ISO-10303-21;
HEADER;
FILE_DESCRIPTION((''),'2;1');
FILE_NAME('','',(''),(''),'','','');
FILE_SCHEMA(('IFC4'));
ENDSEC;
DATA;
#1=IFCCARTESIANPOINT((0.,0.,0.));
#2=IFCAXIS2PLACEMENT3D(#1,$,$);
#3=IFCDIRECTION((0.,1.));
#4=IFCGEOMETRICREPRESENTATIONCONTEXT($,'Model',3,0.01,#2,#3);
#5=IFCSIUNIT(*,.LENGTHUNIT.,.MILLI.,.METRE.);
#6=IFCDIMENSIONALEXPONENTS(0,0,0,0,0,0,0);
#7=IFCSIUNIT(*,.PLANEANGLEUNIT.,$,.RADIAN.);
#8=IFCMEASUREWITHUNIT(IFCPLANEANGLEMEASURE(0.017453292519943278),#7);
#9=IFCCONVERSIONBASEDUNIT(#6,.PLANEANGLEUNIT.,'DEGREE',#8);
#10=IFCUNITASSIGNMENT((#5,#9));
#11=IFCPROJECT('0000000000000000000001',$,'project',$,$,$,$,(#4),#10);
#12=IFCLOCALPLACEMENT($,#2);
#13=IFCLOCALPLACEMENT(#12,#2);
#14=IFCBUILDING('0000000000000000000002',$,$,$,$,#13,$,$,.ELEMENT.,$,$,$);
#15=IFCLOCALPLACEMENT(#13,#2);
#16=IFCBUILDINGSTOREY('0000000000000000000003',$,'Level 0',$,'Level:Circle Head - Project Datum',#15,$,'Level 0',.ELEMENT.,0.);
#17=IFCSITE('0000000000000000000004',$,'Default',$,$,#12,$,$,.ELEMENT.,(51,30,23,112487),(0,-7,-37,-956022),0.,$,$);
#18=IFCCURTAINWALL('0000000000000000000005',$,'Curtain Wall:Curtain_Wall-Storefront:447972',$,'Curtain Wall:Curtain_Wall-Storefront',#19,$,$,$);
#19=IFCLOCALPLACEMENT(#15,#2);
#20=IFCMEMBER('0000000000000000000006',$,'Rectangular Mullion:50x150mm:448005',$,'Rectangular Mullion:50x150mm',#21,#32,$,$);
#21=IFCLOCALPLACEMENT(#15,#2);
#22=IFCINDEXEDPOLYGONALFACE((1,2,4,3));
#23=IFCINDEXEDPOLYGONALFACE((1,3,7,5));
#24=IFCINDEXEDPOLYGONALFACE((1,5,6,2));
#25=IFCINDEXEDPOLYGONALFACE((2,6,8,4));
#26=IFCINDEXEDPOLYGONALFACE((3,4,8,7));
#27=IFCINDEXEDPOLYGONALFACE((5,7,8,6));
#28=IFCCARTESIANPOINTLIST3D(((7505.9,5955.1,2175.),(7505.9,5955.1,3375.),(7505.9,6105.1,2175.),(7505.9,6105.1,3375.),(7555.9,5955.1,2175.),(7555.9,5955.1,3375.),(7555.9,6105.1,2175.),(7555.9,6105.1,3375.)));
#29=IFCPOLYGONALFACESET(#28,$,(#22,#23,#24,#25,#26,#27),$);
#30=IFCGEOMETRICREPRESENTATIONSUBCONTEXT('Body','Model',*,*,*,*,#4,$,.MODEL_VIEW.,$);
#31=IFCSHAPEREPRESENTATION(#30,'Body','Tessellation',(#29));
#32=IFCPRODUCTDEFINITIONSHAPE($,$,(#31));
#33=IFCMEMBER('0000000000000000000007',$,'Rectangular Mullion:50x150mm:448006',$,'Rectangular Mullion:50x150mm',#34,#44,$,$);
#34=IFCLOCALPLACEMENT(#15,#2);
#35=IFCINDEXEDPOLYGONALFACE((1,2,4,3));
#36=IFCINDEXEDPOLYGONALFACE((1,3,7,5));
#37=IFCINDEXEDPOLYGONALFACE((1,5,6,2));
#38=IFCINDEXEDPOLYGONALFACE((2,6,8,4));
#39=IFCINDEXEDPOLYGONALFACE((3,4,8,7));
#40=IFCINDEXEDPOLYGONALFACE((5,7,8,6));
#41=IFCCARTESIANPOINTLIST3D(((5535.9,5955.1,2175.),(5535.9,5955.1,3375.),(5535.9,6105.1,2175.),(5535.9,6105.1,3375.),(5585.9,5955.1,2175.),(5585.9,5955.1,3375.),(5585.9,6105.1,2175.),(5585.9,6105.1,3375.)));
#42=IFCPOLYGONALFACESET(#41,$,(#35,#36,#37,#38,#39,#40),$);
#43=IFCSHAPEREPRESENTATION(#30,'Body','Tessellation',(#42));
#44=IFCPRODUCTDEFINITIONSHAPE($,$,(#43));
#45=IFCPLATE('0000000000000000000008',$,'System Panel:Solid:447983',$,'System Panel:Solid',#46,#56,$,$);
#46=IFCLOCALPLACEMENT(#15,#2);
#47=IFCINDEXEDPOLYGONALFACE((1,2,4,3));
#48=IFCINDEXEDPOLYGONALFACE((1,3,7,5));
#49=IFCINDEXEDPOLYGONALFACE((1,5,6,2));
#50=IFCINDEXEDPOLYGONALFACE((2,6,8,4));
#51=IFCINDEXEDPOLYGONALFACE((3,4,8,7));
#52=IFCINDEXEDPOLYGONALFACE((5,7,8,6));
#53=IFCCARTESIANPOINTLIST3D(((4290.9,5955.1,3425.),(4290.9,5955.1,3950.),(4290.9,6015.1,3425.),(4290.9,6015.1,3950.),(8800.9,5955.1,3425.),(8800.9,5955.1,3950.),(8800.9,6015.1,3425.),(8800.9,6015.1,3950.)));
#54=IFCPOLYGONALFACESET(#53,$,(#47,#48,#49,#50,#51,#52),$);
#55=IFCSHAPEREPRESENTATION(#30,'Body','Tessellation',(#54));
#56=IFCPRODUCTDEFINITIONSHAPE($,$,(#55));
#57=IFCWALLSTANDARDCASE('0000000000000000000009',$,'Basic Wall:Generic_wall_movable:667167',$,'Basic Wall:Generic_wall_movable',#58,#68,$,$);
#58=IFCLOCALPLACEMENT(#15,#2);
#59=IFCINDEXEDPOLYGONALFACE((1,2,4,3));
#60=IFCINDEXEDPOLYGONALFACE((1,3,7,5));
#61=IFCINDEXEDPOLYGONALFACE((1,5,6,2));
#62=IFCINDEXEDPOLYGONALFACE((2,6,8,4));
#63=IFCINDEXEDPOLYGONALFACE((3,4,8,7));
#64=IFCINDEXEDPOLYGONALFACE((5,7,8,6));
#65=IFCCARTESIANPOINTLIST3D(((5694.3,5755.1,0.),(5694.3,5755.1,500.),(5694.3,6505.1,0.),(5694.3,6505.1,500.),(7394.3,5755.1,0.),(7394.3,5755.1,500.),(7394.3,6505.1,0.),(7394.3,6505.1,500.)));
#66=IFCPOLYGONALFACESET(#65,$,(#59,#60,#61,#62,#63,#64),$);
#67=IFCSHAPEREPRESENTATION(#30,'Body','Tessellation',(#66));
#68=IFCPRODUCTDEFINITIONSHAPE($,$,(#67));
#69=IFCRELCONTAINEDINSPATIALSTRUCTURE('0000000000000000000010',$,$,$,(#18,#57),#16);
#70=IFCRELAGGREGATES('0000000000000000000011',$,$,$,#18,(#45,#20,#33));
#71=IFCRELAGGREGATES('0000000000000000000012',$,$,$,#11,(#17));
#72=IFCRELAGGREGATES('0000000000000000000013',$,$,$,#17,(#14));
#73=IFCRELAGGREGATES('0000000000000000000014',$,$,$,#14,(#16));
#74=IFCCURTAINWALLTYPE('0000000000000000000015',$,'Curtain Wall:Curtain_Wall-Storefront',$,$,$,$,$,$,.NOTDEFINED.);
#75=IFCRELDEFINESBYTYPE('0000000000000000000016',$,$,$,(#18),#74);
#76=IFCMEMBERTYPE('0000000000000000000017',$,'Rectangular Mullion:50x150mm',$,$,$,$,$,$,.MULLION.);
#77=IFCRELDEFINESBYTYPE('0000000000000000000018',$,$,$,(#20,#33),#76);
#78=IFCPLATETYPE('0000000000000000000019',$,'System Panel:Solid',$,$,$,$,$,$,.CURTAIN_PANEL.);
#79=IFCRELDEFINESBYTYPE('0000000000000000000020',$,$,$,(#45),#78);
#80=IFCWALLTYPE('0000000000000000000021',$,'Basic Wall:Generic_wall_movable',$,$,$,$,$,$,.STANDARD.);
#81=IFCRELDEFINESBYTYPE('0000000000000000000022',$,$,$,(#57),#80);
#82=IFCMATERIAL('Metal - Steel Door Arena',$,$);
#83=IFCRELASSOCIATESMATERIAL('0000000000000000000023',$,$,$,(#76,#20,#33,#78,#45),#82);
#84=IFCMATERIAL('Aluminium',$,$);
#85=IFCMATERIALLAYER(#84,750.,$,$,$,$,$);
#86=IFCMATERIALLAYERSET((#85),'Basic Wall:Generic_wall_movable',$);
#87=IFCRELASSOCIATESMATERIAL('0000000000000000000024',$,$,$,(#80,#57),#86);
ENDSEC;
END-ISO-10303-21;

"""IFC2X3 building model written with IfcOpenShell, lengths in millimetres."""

from ifc_helpers import new_model, entity, si_unit, converted_unit, direction, frame, frame_2d, origin, origin_2d_with_axis, place, context, subcontext, project, spatial, rectangle, extrude, source, transform, mapped, material, layer, layer_set, layer_usage, type_object, type_shapes, element, aggregate, save


model = new_model("IFC2X3")

# Units and contexts
model_context = context("Model", 3, precision=0.01, world=origin(), true_north=direction((0.0, 1.0)))
body_context = subcontext(model_context, "Body", "Model", "MODEL_VIEW")
ifc_project = project(units=[si_unit("LENGTHUNIT", "METRE", prefix="MILLI"), converted_unit("PLANEANGLEUNIT", "DEGREE", entity("IfcPlaneAngleMeasure", 0.017453292519943278), si_unit("PLANEANGLEUNIT", "RADIAN"), dimensions=[0, 0, 0, 0, 0, 0, 0])], contexts=[model_context])

# Site, building, storey
site_placement = place(None, origin())
site = spatial("IfcSite", under=ifc_project, at=site_placement, Name="Default", CompositionType="ELEMENT", RefLatitude=(51, 30, 23, 112487), RefLongitude=(0, -7, -37, -956022), RefElevation=0.0)
building_placement = place(site_placement, origin())
building = spatial("IfcBuilding", under=site, at=building_placement, CompositionType="ELEMENT")
storey_placement = place(building_placement, origin())
storey = spatial("IfcBuildingStorey", under=building, at=storey_placement, Name="Level 0", ObjectType="Level:Circle Head - Project Datum", LongName="Level 0", CompositionType="ELEMENT", Elevation=0.0)

# Curtain wall, members, plate
curtain_wall_type = type_object("IfcCurtainWallType", Name="Curtain Wall:Curtain_Wall-Storefront", PredefinedType="NOTDEFINED")
curtain_wall_placement = place(storey_placement, origin())
curtain_wall = element("IfcCurtainWall", 1, at=curtain_wall_placement, inside=storey, type_object=curtain_wall_type, Name="Curtain Wall:Curtain_Wall-Storefront:447972", ObjectType="Curtain Wall:Curtain_Wall-Storefront")
ifc_material_1 = material(Name="Metal - Steel Door Arena")
member_type_1 = type_object("IfcMemberType", Name="Rectangular Mullion:50x150mm", PredefinedType="MULLION", material=ifc_material_1)
shared_shape_1 = source(origin(), body_context, "Body", "SweptSolid", [
    extrude(rectangle(XDim=50.0, YDim=150.0, at=origin_2d_with_axis()), frame((0.0, 0.0, -1200.0), z_axis=(0.0, 0.0, 1.0), x_axis=(-1.0, 0.0, 0.0)), (0.0, 0.0, 1.0), 1200.0),
])
type_shapes(member_type_1, [shared_shape_1])
member_1_placement = place(curtain_wall_placement, frame((7530.9, 6030.1, 2175.0), z_axis=(0.0, 0.0, -1.0), x_axis=(-1.0, 0.0, 0.0)))
member_1 = element("IfcMember", 2, at=member_1_placement, type_object=member_type_1, material=ifc_material_1, Name="Rectangular Mullion:50x150mm:448005", ObjectType="Rectangular Mullion:50x150mm", context=body_context, shape_type="MappedRepresentation", body=[
    mapped(shared_shape_1, transform((0.0, 0.0, 0.0), scale=1.0)),
])
member_2_placement = place(curtain_wall_placement, frame((5560.9, 6030.1, 2175.0), z_axis=(0.0, 0.0, -1.0), x_axis=(-1.0, 0.0, 0.0)))
member_2 = element("IfcMember", 3, at=member_2_placement, type_object=member_type_1, material=ifc_material_1, Name="Rectangular Mullion:50x150mm:448006", ObjectType="Rectangular Mullion:50x150mm", context=body_context, shape_type="MappedRepresentation", body=[
    mapped(shared_shape_1, transform((0.0, 0.0, 0.0), scale=1.0)),
])
plate_type_1 = type_object("IfcPlateType", Name="System Panel:Solid", PredefinedType="CURTAIN_PANEL", material=ifc_material_1)
shared_shape_2 = source(origin(), body_context, "Body", "SweptSolid", [
    extrude(rectangle(XDim=525.0, YDim=4510.0, at=frame_2d((0.0, 0.0), x_axis=(1.0, 0.0))), frame((0.0, 15.0, 262.5), z_axis=(0.0, 1.0, 0.0), x_axis=(0.0, 0.0, 1.0)), (0.0, 0.0, 1.0), 60.0),
])
type_shapes(plate_type_1, [shared_shape_2])
plate_1_placement = place(curtain_wall_placement, frame((6545.9, 6030.1, 3425.0), z_axis=(0.0, 0.0, 1.0), x_axis=(-1.0, 0.0, 0.0)))
plate_1 = element("IfcPlate", 4, at=plate_1_placement, type_object=plate_type_1, material=ifc_material_1, Name="System Panel:Solid:447983", ObjectType="System Panel:Solid", context=body_context, shape_type="MappedRepresentation", body=[
    mapped(shared_shape_2, transform((0.0, 0.0, 0.0), scale=1.0)),
])
aggregate(curtain_wall, [plate_1, member_1, member_2])

# Wall
ifc_material_2 = material(Name="Aluminium")
ifc_layer = layer(ifc_material_2, 750.0)
ifc_layer_set = layer_set([ifc_layer], Name="Basic Wall:Generic_wall_movable")
ifc_layer_usage = layer_usage(ifc_layer_set, "AXIS2", "NEGATIVE", 375.0)
wall_type = type_object("IfcWallType", Name="Basic Wall:Generic_wall_movable", PredefinedType="STANDARD", material=ifc_layer_set)
wall_placement = place(storey_placement, frame((5694.3, 6130.1, 0.0)))
element("IfcWallStandardCase", 5, at=wall_placement, inside=storey, type_object=wall_type, material=ifc_layer_usage, Name="Basic Wall:Generic_wall_movable:667167", ObjectType="Basic Wall:Generic_wall_movable", context=body_context, shape_type="SweptSolid", body=[
    extrude(rectangle(XDim=1700.0, YDim=750.0, at=frame_2d((850.0, 0.0), x_axis=(-1.0, 0.0))), origin(), (0.0, 0.0, 1.0), 500.0),
])

save(model, "model.ifc")
